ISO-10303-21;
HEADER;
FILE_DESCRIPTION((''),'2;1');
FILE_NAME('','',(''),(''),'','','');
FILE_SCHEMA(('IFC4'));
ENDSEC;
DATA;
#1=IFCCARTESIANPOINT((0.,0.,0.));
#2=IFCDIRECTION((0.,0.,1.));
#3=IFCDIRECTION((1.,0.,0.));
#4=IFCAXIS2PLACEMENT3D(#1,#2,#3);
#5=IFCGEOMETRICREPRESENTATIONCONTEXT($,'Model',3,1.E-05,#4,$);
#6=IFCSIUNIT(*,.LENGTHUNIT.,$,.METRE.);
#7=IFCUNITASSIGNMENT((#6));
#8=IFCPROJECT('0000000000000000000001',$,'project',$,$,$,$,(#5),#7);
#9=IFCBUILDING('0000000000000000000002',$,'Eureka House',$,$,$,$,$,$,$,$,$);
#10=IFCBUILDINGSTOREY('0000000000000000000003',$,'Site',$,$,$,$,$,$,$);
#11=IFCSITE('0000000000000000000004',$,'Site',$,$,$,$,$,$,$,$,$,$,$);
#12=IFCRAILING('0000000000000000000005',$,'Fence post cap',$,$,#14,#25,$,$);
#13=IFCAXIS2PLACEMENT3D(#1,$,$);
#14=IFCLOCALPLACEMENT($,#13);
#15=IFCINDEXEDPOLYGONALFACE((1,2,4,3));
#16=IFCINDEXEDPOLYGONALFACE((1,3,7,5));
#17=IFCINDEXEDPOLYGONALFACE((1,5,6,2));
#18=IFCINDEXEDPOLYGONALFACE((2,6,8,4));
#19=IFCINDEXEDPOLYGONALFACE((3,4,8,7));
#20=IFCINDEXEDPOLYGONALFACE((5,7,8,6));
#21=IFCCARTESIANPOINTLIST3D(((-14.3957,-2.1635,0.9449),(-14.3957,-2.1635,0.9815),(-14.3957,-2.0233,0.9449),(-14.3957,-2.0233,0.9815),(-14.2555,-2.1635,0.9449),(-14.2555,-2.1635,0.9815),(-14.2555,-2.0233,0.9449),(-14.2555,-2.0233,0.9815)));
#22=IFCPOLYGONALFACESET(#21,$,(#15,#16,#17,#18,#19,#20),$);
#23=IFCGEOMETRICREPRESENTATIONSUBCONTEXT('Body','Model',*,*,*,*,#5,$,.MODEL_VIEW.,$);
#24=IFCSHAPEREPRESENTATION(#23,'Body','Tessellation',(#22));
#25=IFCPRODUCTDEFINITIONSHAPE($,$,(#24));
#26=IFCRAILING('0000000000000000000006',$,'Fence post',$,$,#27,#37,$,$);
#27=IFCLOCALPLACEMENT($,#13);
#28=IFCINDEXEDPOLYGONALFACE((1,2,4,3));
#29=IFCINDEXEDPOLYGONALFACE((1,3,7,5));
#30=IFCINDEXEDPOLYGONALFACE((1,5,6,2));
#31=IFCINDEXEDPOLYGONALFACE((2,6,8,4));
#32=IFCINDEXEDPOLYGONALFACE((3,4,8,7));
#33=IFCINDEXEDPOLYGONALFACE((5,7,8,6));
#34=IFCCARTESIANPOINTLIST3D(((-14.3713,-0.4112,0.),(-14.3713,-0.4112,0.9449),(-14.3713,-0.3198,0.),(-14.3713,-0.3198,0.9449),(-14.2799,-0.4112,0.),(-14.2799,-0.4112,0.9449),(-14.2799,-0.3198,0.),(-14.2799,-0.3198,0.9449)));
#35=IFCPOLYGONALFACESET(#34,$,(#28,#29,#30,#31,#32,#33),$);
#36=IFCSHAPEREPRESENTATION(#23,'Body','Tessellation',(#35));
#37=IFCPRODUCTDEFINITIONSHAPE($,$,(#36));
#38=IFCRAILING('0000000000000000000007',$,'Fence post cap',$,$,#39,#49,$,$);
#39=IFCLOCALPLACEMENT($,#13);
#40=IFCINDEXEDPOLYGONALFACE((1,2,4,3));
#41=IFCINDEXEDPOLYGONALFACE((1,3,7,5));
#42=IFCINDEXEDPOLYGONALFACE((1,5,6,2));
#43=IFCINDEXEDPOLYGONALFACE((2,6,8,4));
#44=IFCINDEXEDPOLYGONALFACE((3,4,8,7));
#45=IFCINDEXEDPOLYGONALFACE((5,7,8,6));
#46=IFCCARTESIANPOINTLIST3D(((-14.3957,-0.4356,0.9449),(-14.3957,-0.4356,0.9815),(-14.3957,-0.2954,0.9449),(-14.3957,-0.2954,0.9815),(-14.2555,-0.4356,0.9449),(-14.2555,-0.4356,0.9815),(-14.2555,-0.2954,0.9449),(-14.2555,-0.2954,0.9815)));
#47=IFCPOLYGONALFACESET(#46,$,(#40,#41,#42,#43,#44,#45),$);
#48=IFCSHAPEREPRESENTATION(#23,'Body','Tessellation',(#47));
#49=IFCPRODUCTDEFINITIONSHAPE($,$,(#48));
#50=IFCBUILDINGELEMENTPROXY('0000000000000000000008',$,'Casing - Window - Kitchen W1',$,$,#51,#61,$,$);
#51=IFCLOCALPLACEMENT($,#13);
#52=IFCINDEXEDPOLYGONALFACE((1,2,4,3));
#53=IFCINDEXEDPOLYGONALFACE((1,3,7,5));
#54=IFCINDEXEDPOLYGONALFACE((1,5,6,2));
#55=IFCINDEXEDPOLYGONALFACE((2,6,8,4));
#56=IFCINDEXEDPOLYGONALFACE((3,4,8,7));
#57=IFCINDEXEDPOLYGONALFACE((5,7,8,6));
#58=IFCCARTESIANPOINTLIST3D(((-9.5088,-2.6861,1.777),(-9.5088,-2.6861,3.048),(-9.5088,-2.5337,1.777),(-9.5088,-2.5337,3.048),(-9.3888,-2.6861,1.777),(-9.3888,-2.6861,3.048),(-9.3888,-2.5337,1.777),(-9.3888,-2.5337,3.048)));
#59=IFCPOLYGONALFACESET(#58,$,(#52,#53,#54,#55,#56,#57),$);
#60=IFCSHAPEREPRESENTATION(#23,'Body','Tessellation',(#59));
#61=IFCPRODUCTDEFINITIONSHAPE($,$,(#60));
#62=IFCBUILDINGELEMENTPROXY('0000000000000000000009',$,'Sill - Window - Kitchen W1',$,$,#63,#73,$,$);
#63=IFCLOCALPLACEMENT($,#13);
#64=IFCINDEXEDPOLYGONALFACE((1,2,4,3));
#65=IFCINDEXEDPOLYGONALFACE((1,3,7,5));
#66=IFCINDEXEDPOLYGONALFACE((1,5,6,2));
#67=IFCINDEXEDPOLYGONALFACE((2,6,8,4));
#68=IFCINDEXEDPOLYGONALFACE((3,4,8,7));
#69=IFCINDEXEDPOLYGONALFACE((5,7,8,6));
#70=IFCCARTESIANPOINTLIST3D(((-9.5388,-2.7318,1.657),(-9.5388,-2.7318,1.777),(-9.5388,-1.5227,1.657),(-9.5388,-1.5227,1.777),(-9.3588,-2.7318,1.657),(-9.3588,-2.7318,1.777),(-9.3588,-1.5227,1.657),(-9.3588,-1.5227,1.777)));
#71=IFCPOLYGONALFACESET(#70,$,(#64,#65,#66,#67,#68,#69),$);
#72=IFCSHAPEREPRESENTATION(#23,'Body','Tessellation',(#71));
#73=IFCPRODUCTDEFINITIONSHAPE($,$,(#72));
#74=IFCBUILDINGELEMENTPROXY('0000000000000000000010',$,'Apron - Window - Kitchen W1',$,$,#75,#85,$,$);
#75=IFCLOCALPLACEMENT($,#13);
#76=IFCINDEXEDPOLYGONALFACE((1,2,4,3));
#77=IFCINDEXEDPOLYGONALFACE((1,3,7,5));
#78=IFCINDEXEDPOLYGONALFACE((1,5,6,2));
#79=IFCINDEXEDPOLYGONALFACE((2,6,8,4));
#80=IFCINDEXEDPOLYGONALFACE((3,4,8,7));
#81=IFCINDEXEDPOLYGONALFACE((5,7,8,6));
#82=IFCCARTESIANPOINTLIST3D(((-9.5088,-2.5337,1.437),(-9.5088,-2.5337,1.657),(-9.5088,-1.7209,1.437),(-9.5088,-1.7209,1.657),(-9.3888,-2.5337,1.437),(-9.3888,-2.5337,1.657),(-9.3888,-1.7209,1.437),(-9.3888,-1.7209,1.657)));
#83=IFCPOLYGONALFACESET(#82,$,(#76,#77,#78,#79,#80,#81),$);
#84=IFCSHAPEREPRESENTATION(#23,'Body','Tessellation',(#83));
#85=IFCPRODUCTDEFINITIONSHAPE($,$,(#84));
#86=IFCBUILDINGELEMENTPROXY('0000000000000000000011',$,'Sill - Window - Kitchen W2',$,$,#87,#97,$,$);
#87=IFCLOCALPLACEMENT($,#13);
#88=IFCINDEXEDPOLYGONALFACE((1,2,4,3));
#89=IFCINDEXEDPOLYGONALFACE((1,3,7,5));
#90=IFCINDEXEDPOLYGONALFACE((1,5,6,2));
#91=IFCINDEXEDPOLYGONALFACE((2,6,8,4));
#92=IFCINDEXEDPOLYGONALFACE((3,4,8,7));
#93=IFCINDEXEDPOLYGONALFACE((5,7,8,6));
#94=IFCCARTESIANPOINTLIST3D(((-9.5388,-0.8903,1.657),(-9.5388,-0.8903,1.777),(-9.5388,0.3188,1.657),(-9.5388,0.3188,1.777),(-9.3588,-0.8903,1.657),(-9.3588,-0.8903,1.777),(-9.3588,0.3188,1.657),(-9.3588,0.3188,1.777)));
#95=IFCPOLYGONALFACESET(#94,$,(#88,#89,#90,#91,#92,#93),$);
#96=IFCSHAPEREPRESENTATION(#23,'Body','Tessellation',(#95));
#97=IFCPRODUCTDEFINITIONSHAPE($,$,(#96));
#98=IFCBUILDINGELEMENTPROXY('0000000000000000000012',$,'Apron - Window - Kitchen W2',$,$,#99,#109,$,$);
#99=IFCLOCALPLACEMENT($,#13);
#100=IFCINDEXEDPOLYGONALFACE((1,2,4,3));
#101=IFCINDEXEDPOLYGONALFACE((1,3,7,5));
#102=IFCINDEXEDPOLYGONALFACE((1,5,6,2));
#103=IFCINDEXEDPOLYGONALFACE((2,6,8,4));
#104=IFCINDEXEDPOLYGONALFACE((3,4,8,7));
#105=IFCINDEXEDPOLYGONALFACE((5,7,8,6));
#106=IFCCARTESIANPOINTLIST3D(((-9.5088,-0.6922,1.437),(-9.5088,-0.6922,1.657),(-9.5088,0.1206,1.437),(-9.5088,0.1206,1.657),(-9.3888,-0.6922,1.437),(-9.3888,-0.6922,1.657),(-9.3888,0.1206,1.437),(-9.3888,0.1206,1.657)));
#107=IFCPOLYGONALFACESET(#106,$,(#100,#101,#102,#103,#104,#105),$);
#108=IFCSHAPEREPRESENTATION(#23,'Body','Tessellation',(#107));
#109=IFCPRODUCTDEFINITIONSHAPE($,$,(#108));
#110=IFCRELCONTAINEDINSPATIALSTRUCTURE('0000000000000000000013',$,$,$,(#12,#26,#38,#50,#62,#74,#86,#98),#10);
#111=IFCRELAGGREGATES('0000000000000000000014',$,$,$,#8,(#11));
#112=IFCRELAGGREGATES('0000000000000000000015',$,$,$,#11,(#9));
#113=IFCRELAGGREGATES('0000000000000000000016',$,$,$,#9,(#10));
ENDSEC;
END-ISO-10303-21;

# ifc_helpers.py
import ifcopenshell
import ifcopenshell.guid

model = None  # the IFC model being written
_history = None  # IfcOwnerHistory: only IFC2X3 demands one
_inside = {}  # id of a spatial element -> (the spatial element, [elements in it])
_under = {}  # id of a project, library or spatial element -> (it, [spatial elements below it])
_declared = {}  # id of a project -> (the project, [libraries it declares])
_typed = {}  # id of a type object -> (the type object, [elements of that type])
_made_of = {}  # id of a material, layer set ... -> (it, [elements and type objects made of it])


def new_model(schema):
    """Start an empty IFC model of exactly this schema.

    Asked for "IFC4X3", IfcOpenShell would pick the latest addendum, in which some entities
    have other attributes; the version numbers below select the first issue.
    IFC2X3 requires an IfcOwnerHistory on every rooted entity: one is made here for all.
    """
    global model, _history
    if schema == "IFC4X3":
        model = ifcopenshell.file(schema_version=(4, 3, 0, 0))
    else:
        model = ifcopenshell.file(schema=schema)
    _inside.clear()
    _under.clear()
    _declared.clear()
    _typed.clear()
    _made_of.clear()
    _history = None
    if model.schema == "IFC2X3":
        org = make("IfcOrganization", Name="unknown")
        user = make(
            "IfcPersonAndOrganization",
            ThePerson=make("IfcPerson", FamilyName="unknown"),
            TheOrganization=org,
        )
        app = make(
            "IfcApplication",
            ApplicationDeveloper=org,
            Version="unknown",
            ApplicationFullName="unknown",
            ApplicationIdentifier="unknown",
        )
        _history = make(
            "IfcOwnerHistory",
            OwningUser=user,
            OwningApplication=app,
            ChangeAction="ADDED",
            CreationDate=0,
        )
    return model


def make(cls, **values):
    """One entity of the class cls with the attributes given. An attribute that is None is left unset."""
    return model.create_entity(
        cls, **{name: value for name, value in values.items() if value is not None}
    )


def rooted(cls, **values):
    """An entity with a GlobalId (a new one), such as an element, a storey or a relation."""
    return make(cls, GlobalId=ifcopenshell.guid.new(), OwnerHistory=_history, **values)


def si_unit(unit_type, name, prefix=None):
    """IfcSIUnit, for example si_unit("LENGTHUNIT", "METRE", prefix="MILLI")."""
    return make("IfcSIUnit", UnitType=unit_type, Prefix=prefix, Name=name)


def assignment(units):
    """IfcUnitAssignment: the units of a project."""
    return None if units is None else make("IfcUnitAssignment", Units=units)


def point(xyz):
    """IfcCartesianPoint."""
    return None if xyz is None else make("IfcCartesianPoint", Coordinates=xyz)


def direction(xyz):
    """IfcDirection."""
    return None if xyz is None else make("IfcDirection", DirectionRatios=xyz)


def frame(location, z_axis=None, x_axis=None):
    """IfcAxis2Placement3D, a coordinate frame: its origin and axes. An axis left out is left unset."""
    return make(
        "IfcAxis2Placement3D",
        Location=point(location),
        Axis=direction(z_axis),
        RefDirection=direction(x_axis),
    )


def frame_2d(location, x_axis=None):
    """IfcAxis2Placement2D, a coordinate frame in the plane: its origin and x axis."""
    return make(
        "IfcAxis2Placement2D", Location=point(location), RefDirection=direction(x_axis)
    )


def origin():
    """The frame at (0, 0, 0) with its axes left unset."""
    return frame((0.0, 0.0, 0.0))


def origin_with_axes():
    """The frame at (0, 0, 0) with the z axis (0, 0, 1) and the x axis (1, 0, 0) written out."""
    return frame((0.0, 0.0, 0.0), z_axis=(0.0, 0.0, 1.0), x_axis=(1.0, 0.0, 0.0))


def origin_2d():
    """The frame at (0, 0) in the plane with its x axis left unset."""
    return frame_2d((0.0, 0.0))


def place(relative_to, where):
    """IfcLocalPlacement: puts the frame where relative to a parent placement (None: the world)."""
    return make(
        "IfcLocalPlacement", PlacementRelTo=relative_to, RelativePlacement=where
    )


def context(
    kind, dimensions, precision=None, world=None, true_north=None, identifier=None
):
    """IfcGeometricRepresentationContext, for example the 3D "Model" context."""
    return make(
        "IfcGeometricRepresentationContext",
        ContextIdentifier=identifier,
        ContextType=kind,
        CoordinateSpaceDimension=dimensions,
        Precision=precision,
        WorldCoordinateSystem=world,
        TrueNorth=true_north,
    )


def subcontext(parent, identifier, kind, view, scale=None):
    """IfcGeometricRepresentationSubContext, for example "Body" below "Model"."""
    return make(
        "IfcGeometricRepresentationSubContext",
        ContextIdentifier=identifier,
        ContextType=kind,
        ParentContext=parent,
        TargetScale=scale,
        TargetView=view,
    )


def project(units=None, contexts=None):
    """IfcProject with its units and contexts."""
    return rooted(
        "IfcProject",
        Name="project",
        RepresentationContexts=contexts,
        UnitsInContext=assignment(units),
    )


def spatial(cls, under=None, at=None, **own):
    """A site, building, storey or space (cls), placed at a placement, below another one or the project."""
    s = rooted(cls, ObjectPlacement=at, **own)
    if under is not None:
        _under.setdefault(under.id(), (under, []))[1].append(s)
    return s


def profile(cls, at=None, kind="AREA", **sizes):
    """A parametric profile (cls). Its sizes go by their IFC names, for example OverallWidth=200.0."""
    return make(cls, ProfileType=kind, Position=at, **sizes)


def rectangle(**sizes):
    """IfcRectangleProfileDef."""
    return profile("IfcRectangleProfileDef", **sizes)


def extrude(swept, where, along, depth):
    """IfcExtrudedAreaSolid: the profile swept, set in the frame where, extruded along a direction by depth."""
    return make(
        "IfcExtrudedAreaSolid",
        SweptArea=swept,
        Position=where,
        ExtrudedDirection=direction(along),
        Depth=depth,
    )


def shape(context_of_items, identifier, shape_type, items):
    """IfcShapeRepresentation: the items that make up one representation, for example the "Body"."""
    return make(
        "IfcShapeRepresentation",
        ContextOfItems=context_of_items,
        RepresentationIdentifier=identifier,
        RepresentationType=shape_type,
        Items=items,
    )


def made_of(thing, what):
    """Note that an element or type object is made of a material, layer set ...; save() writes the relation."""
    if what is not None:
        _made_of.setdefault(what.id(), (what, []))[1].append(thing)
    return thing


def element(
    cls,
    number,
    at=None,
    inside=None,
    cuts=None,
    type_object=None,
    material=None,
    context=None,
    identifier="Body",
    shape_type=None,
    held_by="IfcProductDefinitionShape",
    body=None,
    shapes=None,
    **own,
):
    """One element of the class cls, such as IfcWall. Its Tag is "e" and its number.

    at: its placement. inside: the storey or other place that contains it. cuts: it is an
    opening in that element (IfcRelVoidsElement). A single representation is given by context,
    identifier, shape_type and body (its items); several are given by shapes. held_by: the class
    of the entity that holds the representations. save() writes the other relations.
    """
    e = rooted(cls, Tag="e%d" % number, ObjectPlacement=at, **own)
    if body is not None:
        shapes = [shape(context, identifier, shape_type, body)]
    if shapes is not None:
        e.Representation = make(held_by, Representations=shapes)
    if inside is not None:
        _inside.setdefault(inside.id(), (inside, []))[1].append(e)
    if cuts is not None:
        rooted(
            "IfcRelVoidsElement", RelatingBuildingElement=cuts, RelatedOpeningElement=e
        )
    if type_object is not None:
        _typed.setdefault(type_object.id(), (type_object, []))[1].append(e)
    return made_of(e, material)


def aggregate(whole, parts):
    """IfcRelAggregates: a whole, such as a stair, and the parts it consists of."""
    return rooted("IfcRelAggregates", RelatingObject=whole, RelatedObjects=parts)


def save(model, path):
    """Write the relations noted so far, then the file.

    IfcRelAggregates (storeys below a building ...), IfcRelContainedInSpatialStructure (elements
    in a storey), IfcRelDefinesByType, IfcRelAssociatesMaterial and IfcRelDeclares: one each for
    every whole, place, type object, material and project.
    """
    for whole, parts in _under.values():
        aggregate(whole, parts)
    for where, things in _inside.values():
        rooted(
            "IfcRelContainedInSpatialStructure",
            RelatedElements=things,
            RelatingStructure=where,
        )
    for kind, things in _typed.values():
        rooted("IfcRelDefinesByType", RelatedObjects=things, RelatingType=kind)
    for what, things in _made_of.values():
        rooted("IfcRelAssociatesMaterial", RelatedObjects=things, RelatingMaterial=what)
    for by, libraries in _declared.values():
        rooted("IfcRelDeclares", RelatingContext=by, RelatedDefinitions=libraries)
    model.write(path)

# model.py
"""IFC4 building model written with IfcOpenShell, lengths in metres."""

from ifc_helpers import new_model, si_unit, frame, origin, origin_with_axes, origin_2d, place, context, subcontext, project, spatial, rectangle, extrude, element, save


model = new_model("IFC4")

# Units and contexts
model_context = context("Model", 3, precision=1e-05, world=origin_with_axes())
body_context = subcontext(model_context, "Body", "Model", "MODEL_VIEW")
ifc_project = project(units=[si_unit("LENGTHUNIT", "METRE")], contexts=[model_context])

# Site, building, storey
site = spatial("IfcSite", under=ifc_project, Name="Site")
building = spatial("IfcBuilding", under=site, Name="Eureka House")
storey = spatial("IfcBuildingStorey", under=building, Name="Site")

# Railings
railing_1_placement = place(None, frame((-14.3256, -2.0934, 0.9449), z_axis=(0.0, 0.0, 1.0), x_axis=(1.0, 0.0, 0.0)))
element("IfcRailing", 1, at=railing_1_placement, inside=storey, Name="Fence post cap", context=body_context, shape_type="SweptSolid", body=[
    extrude(rectangle(XDim=0.1402, YDim=0.1402, at=origin_2d()), origin(), (0.0, 0.0, 1.0), 0.0366),
])
railing_2_placement = place(None, frame((-14.3256, -0.3655, 0.0), z_axis=(0.0, 0.0, 1.0), x_axis=(1.0, 0.0, 0.0)))
element("IfcRailing", 2, at=railing_2_placement, inside=storey, Name="Fence post", context=body_context, shape_type="SweptSolid", body=[
    extrude(rectangle(XDim=0.0914, YDim=0.0914, at=origin_2d()), origin(), (0.0, 0.0, 1.0), 0.9449),
])
railing_3_placement = place(None, frame((-14.3256, -0.3655, 0.9449), z_axis=(0.0, 0.0, 1.0), x_axis=(1.0, 0.0, 0.0)))
element("IfcRailing", 3, at=railing_3_placement, inside=storey, Name="Fence post cap", context=body_context, shape_type="SweptSolid", body=[
    extrude(rectangle(XDim=0.1402, YDim=0.1402, at=origin_2d()), origin(), (0.0, 0.0, 1.0), 0.0366),
])

# Building element proxies
proxy_1_placement = place(None, frame((-9.4488, -2.6099, 1.777), z_axis=(0.0, 0.0, 1.0), x_axis=(1.0, 0.0, 0.0)))
element("IfcBuildingElementProxy", 4, at=proxy_1_placement, inside=storey, Name="Casing - Window - Kitchen W1", context=body_context, shape_type="SweptSolid", body=[
    extrude(rectangle(XDim=0.12, YDim=0.1524, at=origin_2d()), origin(), (0.0, 0.0, 1.0), 1.271),
])
proxy_2_placement = place(None, frame((-9.4488, -2.1273, 1.657), z_axis=(0.0, 0.0, 1.0), x_axis=(1.0, 0.0, 0.0)))
element("IfcBuildingElementProxy", 5, at=proxy_2_placement, inside=storey, Name="Sill - Window - Kitchen W1", context=body_context, shape_type="SweptSolid", body=[
    extrude(rectangle(XDim=0.18, YDim=1.209, at=origin_2d()), origin(), (0.0, 0.0, 1.0), 0.12),
])
proxy_3_placement = place(None, frame((-9.4488, -2.1273, 1.437), z_axis=(0.0, 0.0, 1.0), x_axis=(1.0, 0.0, 0.0)))
element("IfcBuildingElementProxy", 6, at=proxy_3_placement, inside=storey, Name="Apron - Window - Kitchen W1", context=body_context, shape_type="SweptSolid", body=[
    extrude(rectangle(XDim=0.12, YDim=0.8128, at=origin_2d()), origin(), (0.0, 0.0, 1.0), 0.22),
])
proxy_4_placement = place(None, frame((-9.4488, -0.2858, 1.657), z_axis=(0.0, 0.0, 1.0), x_axis=(1.0, 0.0, 0.0)))
element("IfcBuildingElementProxy", 7, at=proxy_4_placement, inside=storey, Name="Sill - Window - Kitchen W2", context=body_context, shape_type="SweptSolid", body=[
    extrude(rectangle(XDim=0.18, YDim=1.209, at=origin_2d()), origin(), (0.0, 0.0, 1.0), 0.12),
])
proxy_5_placement = place(None, frame((-9.4488, -0.2858, 1.437), z_axis=(0.0, 0.0, 1.0), x_axis=(1.0, 0.0, 0.0)))
element("IfcBuildingElementProxy", 8, at=proxy_5_placement, inside=storey, Name="Apron - Window - Kitchen W2", context=body_context, shape_type="SweptSolid", body=[
    extrude(rectangle(XDim=0.12, YDim=0.8128, at=origin_2d()), origin(), (0.0, 0.0, 1.0), 0.22),
])

save(model, "model.ifc")
